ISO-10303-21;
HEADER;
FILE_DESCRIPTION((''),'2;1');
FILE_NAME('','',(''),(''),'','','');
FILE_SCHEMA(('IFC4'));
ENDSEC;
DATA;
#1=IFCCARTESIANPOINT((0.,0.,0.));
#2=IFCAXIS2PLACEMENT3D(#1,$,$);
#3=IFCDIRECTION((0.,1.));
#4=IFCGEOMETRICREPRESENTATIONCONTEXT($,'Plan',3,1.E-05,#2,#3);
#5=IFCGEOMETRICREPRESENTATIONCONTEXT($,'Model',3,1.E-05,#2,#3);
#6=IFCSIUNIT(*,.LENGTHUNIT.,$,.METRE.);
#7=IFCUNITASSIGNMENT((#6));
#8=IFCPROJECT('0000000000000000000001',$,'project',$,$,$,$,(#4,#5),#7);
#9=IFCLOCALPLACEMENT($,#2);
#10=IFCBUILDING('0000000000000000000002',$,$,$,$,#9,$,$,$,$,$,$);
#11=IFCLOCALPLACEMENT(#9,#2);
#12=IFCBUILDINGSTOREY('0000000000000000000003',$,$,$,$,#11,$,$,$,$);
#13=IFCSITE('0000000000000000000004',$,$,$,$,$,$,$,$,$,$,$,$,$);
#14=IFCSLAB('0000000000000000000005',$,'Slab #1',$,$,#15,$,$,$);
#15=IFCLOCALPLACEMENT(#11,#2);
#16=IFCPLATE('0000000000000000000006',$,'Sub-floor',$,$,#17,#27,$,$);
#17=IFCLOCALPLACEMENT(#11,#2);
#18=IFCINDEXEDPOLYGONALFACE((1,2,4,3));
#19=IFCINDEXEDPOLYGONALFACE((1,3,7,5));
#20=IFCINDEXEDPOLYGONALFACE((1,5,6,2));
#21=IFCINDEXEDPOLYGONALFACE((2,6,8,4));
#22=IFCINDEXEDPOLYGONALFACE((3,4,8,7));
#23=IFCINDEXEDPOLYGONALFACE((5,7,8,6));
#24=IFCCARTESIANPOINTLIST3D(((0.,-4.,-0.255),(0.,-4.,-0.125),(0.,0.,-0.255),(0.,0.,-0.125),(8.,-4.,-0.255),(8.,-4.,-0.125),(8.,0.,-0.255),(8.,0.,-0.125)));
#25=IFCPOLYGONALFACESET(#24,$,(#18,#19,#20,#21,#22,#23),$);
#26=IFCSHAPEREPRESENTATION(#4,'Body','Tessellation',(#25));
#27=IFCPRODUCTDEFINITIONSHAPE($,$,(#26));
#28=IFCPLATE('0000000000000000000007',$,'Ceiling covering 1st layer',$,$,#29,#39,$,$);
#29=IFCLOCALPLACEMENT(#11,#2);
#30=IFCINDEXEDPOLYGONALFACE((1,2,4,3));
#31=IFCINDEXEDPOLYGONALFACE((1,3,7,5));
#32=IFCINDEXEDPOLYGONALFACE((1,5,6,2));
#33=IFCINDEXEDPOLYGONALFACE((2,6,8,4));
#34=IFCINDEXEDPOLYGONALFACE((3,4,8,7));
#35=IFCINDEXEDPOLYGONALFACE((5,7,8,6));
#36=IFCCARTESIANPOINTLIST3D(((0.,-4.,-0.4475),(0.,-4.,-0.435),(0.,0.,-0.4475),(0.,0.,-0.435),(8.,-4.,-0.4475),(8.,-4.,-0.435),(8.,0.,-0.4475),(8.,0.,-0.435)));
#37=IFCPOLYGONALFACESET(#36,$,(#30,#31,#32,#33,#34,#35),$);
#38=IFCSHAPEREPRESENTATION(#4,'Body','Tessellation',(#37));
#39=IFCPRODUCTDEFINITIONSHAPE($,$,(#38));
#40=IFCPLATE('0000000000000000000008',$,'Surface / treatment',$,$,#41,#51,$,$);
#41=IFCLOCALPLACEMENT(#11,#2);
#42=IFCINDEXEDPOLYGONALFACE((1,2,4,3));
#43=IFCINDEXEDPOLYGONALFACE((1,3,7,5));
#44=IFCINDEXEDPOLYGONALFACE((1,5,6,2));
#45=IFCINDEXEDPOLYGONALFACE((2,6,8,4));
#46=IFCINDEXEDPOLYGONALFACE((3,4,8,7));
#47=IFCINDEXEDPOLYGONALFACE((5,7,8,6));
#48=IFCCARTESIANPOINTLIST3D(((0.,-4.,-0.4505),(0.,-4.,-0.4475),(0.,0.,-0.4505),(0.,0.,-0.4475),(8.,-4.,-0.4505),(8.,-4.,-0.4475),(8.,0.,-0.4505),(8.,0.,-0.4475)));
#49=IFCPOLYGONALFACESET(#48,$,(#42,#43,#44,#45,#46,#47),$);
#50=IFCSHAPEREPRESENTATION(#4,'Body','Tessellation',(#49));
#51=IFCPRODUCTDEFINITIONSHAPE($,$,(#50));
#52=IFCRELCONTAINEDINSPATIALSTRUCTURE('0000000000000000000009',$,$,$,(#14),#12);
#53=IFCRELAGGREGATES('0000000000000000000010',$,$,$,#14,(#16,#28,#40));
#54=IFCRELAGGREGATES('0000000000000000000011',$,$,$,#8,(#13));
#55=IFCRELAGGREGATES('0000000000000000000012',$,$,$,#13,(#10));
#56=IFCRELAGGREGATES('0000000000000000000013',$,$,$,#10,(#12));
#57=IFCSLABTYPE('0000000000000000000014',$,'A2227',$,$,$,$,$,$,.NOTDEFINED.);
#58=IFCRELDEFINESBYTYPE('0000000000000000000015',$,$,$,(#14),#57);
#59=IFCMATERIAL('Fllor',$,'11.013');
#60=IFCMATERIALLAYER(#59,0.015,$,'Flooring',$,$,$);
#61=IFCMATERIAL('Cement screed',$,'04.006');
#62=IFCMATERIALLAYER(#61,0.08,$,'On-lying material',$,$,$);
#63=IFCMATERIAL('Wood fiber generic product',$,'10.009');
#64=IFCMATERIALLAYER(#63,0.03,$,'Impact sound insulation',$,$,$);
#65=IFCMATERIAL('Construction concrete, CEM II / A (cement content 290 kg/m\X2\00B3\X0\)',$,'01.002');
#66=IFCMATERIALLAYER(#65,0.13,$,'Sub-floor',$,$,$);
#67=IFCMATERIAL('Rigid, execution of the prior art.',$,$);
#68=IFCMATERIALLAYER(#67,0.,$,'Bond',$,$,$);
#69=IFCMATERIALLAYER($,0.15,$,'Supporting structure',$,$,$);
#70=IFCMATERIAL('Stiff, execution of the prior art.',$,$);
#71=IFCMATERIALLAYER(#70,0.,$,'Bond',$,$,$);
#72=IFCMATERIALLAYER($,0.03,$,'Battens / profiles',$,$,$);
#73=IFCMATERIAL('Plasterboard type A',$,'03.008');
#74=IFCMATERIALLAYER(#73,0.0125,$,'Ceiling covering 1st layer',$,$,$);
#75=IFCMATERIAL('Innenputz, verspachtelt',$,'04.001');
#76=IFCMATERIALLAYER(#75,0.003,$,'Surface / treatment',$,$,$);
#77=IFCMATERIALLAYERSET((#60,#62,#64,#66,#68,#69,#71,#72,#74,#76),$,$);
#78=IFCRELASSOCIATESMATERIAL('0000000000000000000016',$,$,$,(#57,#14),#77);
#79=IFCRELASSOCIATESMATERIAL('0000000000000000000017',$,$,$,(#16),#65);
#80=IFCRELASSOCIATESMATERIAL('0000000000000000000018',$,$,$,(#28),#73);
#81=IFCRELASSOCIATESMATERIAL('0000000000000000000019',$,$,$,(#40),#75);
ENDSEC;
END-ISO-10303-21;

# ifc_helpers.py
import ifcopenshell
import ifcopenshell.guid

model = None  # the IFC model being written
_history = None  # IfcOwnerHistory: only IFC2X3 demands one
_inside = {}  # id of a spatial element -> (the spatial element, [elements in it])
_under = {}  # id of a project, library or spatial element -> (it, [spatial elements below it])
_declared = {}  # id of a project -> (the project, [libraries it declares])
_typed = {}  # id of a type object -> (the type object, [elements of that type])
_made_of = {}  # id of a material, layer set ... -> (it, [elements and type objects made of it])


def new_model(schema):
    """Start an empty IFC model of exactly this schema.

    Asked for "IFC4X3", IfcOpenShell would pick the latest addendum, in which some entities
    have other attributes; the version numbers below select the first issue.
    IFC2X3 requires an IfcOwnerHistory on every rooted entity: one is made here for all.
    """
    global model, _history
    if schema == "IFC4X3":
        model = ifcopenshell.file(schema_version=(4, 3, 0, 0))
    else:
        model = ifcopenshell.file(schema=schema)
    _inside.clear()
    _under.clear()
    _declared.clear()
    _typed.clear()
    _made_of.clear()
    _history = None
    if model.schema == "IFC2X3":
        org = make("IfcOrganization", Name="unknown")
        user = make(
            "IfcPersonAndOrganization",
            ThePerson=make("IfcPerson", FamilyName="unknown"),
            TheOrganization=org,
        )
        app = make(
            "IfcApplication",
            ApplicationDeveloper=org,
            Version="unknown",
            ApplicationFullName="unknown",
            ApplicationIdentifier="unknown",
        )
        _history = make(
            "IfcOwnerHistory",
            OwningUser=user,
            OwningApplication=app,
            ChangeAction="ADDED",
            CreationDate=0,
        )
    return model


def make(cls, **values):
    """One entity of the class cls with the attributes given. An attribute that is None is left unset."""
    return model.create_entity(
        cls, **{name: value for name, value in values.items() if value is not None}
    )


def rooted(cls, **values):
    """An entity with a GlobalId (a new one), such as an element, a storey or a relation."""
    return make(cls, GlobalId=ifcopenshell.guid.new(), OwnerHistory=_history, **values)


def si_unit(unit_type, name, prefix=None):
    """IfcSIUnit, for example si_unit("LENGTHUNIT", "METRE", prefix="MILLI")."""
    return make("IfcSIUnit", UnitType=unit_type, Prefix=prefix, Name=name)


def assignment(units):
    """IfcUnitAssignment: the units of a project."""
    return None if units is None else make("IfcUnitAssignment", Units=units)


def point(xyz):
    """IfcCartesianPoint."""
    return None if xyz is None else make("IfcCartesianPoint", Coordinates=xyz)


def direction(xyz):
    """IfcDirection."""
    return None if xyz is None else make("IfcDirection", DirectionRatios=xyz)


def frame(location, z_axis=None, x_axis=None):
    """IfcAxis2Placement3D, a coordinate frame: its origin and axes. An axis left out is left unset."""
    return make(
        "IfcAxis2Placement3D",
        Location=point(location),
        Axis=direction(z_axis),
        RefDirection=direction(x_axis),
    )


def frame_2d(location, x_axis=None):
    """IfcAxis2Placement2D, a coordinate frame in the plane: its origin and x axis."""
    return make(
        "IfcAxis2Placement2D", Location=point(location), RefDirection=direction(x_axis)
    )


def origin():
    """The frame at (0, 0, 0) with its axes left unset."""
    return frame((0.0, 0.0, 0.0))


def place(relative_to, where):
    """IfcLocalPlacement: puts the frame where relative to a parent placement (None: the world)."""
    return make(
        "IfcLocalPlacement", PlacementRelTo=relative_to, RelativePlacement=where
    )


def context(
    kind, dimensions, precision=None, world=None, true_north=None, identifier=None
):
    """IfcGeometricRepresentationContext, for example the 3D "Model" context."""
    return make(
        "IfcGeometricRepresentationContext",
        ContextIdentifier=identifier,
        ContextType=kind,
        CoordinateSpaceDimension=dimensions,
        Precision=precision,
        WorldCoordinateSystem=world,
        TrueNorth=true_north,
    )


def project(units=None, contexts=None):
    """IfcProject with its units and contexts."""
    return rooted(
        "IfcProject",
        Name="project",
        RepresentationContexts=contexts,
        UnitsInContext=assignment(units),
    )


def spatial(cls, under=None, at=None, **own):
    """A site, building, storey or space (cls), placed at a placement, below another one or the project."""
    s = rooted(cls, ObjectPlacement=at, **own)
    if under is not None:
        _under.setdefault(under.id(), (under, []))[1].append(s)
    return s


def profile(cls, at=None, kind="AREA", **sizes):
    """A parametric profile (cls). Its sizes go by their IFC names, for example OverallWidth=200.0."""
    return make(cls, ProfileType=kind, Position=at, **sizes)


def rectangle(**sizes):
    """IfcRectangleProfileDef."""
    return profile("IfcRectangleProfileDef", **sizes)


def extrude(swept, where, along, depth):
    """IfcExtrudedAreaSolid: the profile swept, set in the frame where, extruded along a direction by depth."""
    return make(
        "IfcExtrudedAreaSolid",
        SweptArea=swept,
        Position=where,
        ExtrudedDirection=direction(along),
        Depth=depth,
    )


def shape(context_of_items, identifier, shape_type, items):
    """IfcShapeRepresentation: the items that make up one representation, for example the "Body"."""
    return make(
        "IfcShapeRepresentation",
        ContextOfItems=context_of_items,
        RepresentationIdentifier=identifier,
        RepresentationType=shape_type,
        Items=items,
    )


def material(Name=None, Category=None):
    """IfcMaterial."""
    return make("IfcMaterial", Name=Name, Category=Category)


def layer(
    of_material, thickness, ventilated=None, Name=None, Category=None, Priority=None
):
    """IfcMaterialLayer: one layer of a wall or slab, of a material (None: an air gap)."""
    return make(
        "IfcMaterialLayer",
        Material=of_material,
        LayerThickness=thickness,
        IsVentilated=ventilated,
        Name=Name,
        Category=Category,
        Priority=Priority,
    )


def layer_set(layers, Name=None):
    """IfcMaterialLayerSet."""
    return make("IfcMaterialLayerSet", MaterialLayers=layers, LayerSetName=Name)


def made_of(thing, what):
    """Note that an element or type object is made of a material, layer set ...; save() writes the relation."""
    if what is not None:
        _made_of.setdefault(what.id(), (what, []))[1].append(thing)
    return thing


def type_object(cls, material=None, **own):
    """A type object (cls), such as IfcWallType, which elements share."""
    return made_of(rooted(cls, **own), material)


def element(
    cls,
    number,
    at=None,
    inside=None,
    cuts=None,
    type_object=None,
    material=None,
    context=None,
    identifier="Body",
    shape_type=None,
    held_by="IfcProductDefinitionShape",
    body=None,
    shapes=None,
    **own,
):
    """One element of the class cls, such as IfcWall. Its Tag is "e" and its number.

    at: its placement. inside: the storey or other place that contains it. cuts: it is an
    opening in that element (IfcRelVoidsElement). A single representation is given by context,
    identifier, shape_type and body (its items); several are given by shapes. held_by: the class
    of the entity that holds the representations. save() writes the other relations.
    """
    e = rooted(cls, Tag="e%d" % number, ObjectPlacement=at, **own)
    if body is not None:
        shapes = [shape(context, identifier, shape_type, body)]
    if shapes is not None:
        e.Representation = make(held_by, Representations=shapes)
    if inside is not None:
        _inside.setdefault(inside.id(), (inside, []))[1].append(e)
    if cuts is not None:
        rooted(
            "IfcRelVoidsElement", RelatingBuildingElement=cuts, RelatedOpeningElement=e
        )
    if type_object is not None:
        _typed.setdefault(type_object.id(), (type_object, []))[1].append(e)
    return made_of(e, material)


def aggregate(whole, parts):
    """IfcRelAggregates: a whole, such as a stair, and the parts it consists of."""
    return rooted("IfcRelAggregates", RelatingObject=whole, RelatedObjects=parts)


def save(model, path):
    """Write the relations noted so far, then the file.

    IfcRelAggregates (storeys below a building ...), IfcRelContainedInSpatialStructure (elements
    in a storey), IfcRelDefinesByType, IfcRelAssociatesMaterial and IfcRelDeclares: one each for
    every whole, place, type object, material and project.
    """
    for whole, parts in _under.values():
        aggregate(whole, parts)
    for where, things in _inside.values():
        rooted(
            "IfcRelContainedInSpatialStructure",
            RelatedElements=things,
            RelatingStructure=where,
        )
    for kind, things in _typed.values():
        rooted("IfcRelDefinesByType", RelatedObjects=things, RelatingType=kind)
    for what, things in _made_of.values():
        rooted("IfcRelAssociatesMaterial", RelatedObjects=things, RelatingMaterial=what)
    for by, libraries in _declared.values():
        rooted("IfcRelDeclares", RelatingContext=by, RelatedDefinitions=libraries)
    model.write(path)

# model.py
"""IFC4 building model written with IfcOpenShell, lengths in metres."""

from ifc_helpers import new_model, si_unit, direction, frame, frame_2d, origin, place, context, project, spatial, rectangle, extrude, material, layer, layer_set, type_object, element, aggregate, save


model = new_model("IFC4")

# Units and contexts
plan_context = context("Plan", 3, precision=1e-05, world=origin(), true_north=direction((0.0, 1.0)))
model_context = context("Model", 3, precision=1e-05, world=origin(), true_north=direction((0.0, 1.0)))
ifc_project = project(units=[si_unit("LENGTHUNIT", "METRE")], contexts=[plan_context, model_context])

# Site, building, storey
site = spatial("IfcSite", under=ifc_project)
building_placement = place(None, origin())
building = spatial("IfcBuilding", under=site, at=building_placement)
storey_placement = place(building_placement, origin())
storey = spatial("IfcBuildingStorey", under=building, at=storey_placement)

# Slab, plates
ifc_material_1 = material(Name="Fllor", Category="11.013")
ifc_layer_1 = layer(ifc_material_1, 0.015, Name="Flooring")
ifc_material_2 = material(Name="Cement screed", Category="04.006")
ifc_layer_2 = layer(ifc_material_2, 0.08, Name="On-lying material")
ifc_material_3 = material(Name="Wood fiber generic product", Category="10.009")
ifc_layer_3 = layer(ifc_material_3, 0.03, Name="Impact sound insulation")
ifc_material_4 = material(Name="Construction concrete, CEM II / A (cement content 290 kg/m³)", Category="01.002")
ifc_layer_4 = layer(ifc_material_4, 0.13, Name="Sub-floor")
ifc_material_5 = material(Name="Rigid, execution of the prior art.")
ifc_layer_5 = layer(ifc_material_5, 0.0, Name="Bond")
ifc_layer_6 = layer(None, 0.15, Name="Supporting structure")
ifc_material_6 = material(Name="Stiff, execution of the prior art.")
ifc_layer_7 = layer(ifc_material_6, 0.0, Name="Bond")
ifc_layer_8 = layer(None, 0.03, Name="Battens / profiles")
ifc_material_7 = material(Name="Plasterboard type A", Category="03.008")
ifc_layer_9 = layer(ifc_material_7, 0.0125, Name="Ceiling covering 1st layer")
ifc_material_8 = material(Name="Innenputz, verspachtelt", Category="04.001")
ifc_layer_10 = layer(ifc_material_8, 0.003, Name="Surface / treatment")
ifc_layer_set = layer_set([ifc_layer_1, ifc_layer_2, ifc_layer_3, ifc_layer_4, ifc_layer_5, ifc_layer_6, ifc_layer_7, ifc_layer_8, ifc_layer_9, ifc_layer_10])
slab_type = type_object("IfcSlabType", Name="A2227", PredefinedType="NOTDEFINED", material=ifc_layer_set)
slab_placement = place(None, frame((0.0, 0.0, 0.0), z_axis=(0.0, 0.0, -1.0), x_axis=(1.0, 0.0, 0.0)))
slab = element("IfcSlab", 1, at=slab_placement, inside=storey, type_object=slab_type, material=ifc_layer_set, Name="Slab #1")
plate_1_placement = place(slab_placement, origin())
plate_1 = element("IfcPlate", 2, at=plate_1_placement, material=ifc_material_4, Name="Sub-floor", context=plan_context, shape_type="SweptSolid", body=[
    extrude(rectangle(XDim=8.0, YDim=4.0, at=frame_2d((4.0, 2.0), x_axis=(1.0, 0.0))), frame((0.0, 0.0, 0.125), z_axis=(0.0, 0.0, 1.0), x_axis=(1.0, 0.0, 0.0)), (0.0, 0.0, 1.0), 0.13),
])
plate_2_placement = place(slab_placement, origin())
plate_2 = element("IfcPlate", 3, at=plate_2_placement, material=ifc_material_7, Name="Ceiling covering 1st layer", context=plan_context, shape_type="SweptSolid", body=[
    extrude(rectangle(XDim=8.0, YDim=4.0, at=frame_2d((4.0, 2.0), x_axis=(1.0, 0.0))), frame((0.0, 0.0, 0.435), z_axis=(0.0, 0.0, 1.0), x_axis=(1.0, 0.0, 0.0)), (0.0, 0.0, 1.0), 0.0125),
])
plate_3_placement = place(slab_placement, origin())
plate_3 = element("IfcPlate", 4, at=plate_3_placement, material=ifc_material_8, Name="Surface / treatment", context=plan_context, shape_type="SweptSolid", body=[
    extrude(rectangle(XDim=8.0, YDim=4.0, at=frame_2d((4.0, 2.0), x_axis=(1.0, 0.0))), frame((0.0, 0.0, 0.4475), z_axis=(0.0, 0.0, 1.0), x_axis=(1.0, 0.0, 0.0)), (0.0, 0.0, 1.0), 0.003),
])
aggregate(slab, [plate_1, plate_2, plate_3])

save(model, "model.ifc")
